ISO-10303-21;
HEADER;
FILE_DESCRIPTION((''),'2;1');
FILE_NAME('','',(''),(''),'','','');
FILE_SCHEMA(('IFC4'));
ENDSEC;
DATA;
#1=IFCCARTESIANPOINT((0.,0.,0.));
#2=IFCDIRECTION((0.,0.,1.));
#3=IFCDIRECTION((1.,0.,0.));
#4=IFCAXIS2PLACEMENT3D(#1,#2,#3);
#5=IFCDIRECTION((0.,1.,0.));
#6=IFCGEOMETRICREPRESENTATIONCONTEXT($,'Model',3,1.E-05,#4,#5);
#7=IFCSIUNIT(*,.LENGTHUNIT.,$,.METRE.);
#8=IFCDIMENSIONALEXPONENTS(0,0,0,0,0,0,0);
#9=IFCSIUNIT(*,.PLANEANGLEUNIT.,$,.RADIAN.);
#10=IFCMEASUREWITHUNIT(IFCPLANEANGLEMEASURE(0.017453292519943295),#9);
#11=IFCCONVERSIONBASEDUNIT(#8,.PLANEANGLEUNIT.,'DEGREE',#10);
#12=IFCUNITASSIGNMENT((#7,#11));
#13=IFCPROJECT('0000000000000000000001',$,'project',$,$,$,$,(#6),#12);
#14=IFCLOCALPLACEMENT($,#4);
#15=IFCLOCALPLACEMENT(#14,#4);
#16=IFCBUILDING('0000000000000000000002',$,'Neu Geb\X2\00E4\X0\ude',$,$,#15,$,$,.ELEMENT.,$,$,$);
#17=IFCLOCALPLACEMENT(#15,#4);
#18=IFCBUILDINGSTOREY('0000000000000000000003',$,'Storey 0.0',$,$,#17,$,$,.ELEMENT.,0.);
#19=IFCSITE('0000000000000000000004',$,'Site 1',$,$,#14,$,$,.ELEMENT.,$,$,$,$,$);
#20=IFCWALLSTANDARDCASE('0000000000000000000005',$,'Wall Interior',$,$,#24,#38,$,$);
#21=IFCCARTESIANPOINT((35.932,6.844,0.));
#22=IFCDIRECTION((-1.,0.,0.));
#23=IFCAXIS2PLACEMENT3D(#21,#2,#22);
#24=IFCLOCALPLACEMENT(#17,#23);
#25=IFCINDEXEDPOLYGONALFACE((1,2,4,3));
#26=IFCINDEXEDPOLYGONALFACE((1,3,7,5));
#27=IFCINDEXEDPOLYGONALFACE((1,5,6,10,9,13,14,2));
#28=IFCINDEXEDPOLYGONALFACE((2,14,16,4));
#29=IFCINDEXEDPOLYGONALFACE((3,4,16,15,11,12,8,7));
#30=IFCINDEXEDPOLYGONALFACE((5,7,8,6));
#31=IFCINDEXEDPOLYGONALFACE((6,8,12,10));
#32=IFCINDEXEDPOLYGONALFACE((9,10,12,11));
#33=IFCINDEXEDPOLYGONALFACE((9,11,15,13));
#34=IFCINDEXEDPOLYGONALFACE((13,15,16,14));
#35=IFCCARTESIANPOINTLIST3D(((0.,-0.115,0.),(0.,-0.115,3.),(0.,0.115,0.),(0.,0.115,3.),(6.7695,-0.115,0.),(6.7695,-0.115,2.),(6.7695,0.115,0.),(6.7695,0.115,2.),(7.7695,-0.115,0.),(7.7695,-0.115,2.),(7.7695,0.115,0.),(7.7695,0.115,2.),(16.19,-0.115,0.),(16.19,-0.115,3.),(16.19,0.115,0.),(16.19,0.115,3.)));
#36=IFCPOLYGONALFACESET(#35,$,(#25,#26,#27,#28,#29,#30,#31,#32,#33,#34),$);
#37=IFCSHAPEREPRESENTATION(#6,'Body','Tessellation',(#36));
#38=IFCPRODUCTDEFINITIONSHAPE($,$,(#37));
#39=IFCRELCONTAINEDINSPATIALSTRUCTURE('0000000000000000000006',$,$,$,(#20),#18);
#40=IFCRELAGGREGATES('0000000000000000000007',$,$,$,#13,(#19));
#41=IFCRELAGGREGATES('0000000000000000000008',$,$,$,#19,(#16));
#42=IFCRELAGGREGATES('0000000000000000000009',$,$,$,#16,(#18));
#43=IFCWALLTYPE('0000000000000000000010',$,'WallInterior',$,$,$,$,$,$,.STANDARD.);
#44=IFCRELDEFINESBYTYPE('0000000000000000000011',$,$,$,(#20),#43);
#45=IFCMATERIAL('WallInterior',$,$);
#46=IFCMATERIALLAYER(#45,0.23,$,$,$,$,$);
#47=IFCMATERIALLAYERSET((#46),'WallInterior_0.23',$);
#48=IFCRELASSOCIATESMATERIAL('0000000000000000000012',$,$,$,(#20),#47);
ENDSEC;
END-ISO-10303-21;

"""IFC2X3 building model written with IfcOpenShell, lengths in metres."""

from ifc_helpers import new_model, entity, si_unit, converted_unit, direction, frame, origin_with_axes, place, context, project, spatial, polyline, outline, extrude, material, layer, layer_set, layer_usage, type_object, element, save


model = new_model("IFC2X3")

# Units and contexts
model_context = context("Model", 3, precision=1e-05, world=origin_with_axes(), true_north=direction((0.0, 1.0, 0.0)))
ifc_project = project(units=[si_unit("LENGTHUNIT", "METRE"), converted_unit("PLANEANGLEUNIT", "DEGREE", entity("IfcPlaneAngleMeasure", 0.017453292519943295), si_unit("PLANEANGLEUNIT", "RADIAN"), dimensions=[0, 0, 0, 0, 0, 0, 0])], contexts=[model_context])

# Site, building, storey
site_placement = place(None, origin_with_axes())
site = spatial("IfcSite", under=ifc_project, at=site_placement, Name="Site 1", CompositionType="ELEMENT")
building_placement = place(site_placement, origin_with_axes())
building = spatial("IfcBuilding", under=site, at=building_placement, Name="Neu Gebäude", CompositionType="ELEMENT")
storey_placement = place(building_placement, origin_with_axes())
storey = spatial("IfcBuildingStorey", under=building, at=storey_placement, Name="Storey 0.0", CompositionType="ELEMENT", Elevation=0.0)

# Shared definitions
ifc_material_1 = material(Name="WallInterior")
ifc_layer_1 = layer(ifc_material_1, 0.23)
ifc_layer_set_1 = layer_set([ifc_layer_1], Name="WallInterior_0.23")
ifc_layer_usage_1 = layer_usage(ifc_layer_set_1, "AXIS2", "POSITIVE", -0.115)
wall_type_1 = type_object("IfcWallType", Name="WallInterior", PredefinedType="STANDARD")

# Wall, opening
wall_1_placement = place(storey_placement, frame((35.932, 6.844, 0.0), z_axis=(0.0, 0.0, 1.0), x_axis=(-1.0, 0.0, 0.0)))
wall_1 = element("IfcWallStandardCase", 1, at=wall_1_placement, inside=storey, type_object=wall_type_1, material=ifc_layer_usage_1, Name="Wall Interior", context=model_context, shape_type="SweptSolid", body=[
    extrude(outline(polyline([(0.0, -0.115), (16.19, -0.115), (16.19, 0.115), (0.0, 0.115), (0.0, -0.115)])), origin_with_axes(), (0.0, 0.0, 1.0), 3.0),
])
opening_1_placement = place(wall_1_placement, frame((7.2695, 0.0, 0.0), z_axis=(0.0, 0.0, 1.0), x_axis=(1.0, 0.0, 0.0)))
element("IfcOpeningElement", 2, at=opening_1_placement, cuts=wall_1, context=model_context, shape_type="SweptSolid", body=[
    extrude(outline(polyline([(-0.5, 0.252), (0.5, 0.252), (0.5, -0.252), (-0.5, -0.252), (-0.5, 0.252)])), origin_with_axes(), (0.0, 0.0, 1.0), 2.0),
])

save(model, "model.ifc")
